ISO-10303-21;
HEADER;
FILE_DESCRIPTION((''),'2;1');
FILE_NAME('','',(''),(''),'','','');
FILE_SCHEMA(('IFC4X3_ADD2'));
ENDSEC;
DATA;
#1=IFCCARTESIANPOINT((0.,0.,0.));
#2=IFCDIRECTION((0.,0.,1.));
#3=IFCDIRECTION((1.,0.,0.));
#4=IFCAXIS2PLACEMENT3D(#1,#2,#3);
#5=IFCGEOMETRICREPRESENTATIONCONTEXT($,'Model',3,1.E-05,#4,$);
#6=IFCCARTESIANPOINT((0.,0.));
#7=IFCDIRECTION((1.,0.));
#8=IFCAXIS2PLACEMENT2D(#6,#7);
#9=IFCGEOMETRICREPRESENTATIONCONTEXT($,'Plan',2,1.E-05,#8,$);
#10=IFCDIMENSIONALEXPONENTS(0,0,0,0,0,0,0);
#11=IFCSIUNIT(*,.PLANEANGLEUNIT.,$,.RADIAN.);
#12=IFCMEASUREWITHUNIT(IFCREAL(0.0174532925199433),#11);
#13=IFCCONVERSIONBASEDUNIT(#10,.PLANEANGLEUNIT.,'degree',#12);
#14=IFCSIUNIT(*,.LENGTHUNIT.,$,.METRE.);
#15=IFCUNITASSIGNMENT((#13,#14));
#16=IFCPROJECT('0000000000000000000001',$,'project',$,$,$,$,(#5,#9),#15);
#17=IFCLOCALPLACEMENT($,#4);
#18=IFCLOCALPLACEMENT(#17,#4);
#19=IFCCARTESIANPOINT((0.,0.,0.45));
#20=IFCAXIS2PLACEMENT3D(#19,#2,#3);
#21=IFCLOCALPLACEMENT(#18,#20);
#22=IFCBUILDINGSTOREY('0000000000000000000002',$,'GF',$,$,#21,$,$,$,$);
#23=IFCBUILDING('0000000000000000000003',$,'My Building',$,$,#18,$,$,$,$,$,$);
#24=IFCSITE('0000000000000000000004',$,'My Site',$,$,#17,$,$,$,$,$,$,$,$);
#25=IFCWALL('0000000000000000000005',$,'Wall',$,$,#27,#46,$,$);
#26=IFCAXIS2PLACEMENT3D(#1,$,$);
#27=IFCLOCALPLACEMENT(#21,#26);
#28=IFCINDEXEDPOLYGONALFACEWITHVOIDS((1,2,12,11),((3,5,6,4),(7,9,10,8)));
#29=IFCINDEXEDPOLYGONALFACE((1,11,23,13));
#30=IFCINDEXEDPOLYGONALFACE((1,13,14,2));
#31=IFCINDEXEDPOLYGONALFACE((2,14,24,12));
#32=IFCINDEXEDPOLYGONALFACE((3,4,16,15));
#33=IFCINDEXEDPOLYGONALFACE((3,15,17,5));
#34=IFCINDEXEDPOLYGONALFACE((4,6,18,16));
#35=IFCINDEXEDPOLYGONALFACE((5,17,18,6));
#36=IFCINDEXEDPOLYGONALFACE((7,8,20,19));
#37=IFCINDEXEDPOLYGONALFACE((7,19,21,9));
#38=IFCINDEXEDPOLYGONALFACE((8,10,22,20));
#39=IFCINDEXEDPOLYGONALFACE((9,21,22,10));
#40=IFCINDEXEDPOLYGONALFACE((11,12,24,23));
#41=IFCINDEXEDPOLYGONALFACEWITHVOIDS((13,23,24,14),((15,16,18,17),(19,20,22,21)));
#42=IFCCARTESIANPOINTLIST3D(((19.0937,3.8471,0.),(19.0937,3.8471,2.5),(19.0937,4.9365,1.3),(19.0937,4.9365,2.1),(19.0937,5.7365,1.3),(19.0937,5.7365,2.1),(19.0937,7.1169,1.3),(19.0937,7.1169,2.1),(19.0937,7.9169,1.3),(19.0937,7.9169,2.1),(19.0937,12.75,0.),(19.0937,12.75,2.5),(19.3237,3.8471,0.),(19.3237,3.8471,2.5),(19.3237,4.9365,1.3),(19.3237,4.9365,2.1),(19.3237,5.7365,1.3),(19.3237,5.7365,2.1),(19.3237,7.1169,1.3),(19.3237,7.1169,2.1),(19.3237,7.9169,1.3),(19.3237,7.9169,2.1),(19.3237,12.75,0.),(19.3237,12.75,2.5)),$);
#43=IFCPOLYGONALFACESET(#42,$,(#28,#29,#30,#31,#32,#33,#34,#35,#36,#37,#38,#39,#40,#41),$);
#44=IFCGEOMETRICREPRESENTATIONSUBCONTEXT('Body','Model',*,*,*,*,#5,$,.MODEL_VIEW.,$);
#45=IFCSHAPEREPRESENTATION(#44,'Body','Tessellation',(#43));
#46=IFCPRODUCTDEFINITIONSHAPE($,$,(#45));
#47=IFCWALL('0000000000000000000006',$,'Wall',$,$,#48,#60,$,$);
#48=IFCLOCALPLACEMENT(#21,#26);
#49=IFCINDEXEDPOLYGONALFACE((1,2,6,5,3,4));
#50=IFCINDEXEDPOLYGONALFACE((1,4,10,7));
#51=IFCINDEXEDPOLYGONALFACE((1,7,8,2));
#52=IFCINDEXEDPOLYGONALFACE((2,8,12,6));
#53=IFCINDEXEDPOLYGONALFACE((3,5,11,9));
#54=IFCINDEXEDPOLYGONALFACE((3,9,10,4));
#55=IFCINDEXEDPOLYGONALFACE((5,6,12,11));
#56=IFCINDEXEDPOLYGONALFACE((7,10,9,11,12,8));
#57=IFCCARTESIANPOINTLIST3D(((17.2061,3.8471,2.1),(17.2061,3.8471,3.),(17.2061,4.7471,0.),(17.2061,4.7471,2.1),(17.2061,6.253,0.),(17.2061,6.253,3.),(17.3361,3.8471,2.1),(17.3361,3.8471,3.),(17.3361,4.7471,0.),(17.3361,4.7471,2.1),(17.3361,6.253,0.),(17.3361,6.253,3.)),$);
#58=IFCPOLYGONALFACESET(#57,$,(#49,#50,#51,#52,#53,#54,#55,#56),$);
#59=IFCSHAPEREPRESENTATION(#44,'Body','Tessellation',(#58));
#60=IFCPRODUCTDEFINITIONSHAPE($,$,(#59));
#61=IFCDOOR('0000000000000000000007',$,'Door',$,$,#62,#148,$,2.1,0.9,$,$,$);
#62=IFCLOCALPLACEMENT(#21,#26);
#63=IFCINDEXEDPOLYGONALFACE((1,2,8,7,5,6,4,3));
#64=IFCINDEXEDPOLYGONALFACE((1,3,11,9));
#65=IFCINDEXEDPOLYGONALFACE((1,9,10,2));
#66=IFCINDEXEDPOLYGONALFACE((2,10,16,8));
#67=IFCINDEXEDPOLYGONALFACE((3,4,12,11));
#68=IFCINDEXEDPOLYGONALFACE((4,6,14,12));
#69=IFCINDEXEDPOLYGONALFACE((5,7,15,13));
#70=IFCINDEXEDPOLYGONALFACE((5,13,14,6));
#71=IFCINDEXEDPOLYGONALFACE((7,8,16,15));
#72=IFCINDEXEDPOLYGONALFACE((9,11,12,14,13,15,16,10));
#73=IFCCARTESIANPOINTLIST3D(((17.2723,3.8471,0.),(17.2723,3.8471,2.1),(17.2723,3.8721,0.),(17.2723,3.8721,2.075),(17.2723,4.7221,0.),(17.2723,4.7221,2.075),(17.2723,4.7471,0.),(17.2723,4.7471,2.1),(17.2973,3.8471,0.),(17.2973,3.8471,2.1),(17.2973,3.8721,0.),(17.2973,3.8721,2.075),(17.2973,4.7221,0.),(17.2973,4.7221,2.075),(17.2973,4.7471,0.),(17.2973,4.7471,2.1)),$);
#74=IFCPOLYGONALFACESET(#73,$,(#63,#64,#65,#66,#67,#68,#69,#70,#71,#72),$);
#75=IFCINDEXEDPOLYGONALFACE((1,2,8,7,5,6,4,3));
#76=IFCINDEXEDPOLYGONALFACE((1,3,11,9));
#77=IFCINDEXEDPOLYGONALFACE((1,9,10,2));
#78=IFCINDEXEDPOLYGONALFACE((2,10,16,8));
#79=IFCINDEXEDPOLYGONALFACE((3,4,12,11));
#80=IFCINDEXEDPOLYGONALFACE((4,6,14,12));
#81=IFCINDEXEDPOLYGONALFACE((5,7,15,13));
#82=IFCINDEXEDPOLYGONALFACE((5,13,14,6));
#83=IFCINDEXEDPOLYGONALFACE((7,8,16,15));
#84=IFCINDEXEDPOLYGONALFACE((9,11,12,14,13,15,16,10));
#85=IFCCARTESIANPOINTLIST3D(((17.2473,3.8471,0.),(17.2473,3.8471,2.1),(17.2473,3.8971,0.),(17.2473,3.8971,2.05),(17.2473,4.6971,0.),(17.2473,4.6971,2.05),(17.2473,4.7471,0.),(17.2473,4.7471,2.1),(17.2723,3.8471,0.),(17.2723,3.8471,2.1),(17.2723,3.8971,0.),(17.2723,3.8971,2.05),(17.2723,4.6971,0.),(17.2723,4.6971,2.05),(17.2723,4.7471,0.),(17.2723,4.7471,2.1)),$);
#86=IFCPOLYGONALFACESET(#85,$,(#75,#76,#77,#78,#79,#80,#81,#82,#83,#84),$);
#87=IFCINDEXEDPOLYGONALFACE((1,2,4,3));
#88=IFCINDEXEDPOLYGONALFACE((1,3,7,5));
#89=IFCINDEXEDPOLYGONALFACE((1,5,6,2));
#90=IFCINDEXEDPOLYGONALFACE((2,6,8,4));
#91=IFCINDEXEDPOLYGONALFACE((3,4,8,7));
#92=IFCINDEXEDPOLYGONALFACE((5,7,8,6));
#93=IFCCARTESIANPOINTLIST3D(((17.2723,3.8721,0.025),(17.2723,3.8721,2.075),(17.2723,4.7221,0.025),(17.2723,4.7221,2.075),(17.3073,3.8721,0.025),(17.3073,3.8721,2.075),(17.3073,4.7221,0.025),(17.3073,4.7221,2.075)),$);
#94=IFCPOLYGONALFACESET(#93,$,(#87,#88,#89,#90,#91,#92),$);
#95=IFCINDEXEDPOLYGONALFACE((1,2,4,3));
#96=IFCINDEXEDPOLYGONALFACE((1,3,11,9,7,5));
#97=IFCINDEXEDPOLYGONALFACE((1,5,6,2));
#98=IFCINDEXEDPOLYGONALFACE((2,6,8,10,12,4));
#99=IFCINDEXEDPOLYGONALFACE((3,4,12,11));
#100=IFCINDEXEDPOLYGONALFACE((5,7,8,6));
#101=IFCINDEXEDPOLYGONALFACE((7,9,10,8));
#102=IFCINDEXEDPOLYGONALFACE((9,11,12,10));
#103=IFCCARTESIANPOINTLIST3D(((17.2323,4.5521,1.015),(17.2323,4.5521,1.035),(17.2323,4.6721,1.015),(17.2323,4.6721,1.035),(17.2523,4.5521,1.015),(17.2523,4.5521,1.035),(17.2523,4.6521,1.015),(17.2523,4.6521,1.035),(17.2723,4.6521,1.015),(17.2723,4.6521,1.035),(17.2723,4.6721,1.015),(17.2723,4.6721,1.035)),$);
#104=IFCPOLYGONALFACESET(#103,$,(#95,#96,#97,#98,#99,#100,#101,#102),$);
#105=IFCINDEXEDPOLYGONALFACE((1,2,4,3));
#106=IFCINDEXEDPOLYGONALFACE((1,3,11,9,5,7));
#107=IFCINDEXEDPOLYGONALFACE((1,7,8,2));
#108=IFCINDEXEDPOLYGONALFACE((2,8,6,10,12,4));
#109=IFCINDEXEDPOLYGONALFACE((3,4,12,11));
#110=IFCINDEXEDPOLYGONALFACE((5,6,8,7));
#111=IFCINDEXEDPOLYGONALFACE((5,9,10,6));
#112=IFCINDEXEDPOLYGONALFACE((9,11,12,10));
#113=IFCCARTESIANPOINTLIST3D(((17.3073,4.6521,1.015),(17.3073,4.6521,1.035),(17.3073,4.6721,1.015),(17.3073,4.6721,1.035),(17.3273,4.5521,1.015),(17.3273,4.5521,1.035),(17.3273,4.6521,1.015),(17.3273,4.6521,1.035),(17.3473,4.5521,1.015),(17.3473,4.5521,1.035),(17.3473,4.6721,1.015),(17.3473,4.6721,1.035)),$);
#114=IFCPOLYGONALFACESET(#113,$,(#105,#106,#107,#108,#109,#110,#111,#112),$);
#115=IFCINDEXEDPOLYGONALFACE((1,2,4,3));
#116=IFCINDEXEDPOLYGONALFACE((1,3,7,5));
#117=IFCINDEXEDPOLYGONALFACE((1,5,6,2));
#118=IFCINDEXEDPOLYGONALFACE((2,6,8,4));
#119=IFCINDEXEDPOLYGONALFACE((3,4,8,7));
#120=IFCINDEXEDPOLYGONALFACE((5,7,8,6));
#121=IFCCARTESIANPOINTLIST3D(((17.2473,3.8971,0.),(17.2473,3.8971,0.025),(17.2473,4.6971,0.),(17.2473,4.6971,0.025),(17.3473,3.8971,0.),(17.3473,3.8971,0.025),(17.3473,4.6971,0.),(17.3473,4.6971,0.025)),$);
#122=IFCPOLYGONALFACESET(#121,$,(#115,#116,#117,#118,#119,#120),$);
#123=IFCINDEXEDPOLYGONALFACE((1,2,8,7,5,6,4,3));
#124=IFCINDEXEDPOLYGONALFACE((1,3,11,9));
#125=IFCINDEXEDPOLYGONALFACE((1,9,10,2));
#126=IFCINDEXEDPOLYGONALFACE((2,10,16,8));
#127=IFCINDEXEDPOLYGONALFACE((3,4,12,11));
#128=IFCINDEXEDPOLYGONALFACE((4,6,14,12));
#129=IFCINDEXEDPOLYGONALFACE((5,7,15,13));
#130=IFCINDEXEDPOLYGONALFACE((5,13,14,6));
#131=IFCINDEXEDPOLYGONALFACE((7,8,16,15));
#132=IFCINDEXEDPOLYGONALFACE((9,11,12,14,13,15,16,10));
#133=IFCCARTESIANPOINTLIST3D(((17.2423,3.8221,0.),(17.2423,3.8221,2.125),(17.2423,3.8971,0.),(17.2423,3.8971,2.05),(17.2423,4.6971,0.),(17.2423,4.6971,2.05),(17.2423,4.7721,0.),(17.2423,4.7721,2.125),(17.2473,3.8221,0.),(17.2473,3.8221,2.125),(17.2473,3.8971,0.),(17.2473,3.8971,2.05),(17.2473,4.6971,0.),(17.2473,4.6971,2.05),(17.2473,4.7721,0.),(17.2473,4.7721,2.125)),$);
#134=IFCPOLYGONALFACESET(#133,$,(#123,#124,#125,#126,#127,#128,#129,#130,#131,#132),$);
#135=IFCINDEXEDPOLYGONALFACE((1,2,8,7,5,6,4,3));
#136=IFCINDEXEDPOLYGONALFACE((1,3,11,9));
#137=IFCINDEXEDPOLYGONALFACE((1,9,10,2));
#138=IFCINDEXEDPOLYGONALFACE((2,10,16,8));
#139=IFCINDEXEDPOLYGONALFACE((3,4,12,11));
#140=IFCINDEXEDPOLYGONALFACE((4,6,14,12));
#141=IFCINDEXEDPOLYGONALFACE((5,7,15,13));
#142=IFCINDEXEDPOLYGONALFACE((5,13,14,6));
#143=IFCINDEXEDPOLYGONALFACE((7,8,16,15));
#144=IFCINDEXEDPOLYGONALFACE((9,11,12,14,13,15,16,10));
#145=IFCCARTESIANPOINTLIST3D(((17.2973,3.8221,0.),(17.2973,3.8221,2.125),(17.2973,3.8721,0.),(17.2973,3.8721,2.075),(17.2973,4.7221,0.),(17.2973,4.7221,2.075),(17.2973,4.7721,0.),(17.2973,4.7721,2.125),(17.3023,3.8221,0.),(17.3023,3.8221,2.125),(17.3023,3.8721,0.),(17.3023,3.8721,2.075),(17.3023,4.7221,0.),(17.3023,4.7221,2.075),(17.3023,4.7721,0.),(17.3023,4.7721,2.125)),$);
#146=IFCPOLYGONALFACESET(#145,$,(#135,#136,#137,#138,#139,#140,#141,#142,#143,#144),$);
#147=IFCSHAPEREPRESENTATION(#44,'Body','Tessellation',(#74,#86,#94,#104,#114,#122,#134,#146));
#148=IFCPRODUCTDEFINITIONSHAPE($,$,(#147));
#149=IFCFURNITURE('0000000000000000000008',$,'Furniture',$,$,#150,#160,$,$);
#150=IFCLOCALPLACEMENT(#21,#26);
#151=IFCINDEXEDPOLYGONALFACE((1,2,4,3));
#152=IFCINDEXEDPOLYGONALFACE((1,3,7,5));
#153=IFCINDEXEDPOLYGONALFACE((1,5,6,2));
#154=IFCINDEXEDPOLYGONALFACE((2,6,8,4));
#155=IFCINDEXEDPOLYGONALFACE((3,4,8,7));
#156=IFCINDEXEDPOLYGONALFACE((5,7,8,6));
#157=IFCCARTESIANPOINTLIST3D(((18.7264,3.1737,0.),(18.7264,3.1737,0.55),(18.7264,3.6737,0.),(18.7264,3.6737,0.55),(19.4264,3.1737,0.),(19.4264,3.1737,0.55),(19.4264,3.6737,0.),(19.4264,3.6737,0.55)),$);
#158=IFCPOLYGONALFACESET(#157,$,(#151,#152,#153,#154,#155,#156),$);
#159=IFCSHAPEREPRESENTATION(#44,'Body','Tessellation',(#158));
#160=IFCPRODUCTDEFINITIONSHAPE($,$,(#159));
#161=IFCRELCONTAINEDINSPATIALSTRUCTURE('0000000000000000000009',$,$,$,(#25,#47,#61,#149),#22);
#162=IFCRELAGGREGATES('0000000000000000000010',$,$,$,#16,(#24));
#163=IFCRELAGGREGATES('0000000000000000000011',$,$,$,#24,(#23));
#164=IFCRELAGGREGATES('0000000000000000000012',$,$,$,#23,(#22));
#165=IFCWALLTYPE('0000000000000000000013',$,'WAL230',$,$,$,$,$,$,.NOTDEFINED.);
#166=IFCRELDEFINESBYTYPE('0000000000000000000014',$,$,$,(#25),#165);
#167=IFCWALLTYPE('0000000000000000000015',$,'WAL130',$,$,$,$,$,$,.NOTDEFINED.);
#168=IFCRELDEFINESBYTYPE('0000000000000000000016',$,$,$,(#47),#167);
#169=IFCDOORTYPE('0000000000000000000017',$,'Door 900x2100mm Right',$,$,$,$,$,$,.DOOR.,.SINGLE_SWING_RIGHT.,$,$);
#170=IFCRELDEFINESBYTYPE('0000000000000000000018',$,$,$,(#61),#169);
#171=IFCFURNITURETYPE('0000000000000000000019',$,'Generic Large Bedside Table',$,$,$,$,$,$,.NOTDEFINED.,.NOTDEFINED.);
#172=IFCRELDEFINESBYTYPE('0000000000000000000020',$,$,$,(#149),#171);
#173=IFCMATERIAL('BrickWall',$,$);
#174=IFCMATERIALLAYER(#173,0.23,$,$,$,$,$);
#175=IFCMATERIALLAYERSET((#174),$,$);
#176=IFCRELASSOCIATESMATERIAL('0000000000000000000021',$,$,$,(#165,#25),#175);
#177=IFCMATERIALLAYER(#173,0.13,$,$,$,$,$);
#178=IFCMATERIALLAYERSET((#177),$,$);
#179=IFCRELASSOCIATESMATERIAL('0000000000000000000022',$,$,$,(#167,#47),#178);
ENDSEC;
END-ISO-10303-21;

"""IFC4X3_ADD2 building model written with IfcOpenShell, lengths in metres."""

from ifc_helpers import new_model, entity, si_unit, converted_unit, frame, origin_with_axes, origin_2d_with_axis, place, context, subcontext, project, spatial, line, indexed_curve, outline, extrude, shape, source, transform, mapped, material, layer, layer_set, layer_usage, type_object, type_shapes, element, fill, save


model = new_model("IFC4X3_ADD2")

# Units and contexts
model_context = context("Model", 3, precision=1e-05, world=origin_with_axes())
plan_context = context("Plan", 2, precision=1e-05, world=origin_2d_with_axis())
body_context_1 = subcontext(model_context, "Body", "Model", "MODEL_VIEW")
body_context_2 = subcontext(plan_context, "Body", "Plan", "PLAN_VIEW")
ifc_project = project(units=[converted_unit("PLANEANGLEUNIT", "degree", entity("IfcReal", 0.0174532925199433), si_unit("PLANEANGLEUNIT", "RADIAN"), dimensions=[0, 0, 0, 0, 0, 0, 0]), si_unit("LENGTHUNIT", "METRE")], contexts=[model_context, plan_context])

# Site, building, storey
site_placement = place(None, origin_with_axes())
site = spatial("IfcSite", under=ifc_project, at=site_placement, Name="My Site")
building_placement = place(site_placement, origin_with_axes())
building = spatial("IfcBuilding", under=site, at=building_placement, Name="My Building")
storey_placement = place(building_placement, frame((0.0, 0.0, 0.45), z_axis=(0.0, 0.0, 1.0), x_axis=(1.0, 0.0, 0.0)))
storey = spatial("IfcBuildingStorey", under=building, at=storey_placement, Name="GF")

# Shared definitions
ifc_material = material(Name="BrickWall")
ifc_layer_1 = layer(ifc_material, 0.23)
ifc_layer_set_1 = layer_set([ifc_layer_1])
wall_type_1 = type_object("IfcWallType", Name="WAL230", PredefinedType="NOTDEFINED", material=ifc_layer_set_1)

# Wall, openings
ifc_layer_usage_1 = layer_usage(ifc_layer_set_1, "AXIS2", "POSITIVE", 0.0)
wall_1_placement = place(storey_placement, frame((19.3237, 3.8471, 0.0), z_axis=(0.0, 0.0, 1.0), x_axis=(0.0, 1.0, 0.0)))
wall_1 = element("IfcWall", 1, at=wall_1_placement, inside=storey, type_object=wall_type_1, material=ifc_layer_usage_1, Name="Wall", context=body_context_1, shape_type="SweptSolid", body=[
    extrude(outline(indexed_curve([(0.0, 0.0), (0.0, 0.23), (8.9029, 0.23), (8.9029, 0.0), (0.0, 0.0)], self_intersect=False)), origin_with_axes(), (0.0, 0.0, 1.0), 2.5),
])
shared_shape_1 = source(origin_with_axes(), body_context_1, "Body", "SweptSolid", [
    extrude(outline(indexed_curve([(0.0, 0.0), (0.8, 0.0), (0.8, 0.8), (0.0, 0.8)], segments=[line(1, 2, 3, 4, 1)])), frame((-0.4, -0.6, 0.0), z_axis=(0.0, -1.0, 0.0), x_axis=(1.0, 0.0, 0.0)), (0.0, 0.0, -1.0), 1.2),
])
opening_1_placement = place(wall_1_placement, frame((1.4894, 0.0, 1.3), z_axis=(0.0, 0.0, 1.0), x_axis=(1.0, 0.0, 0.0)))
element("IfcOpeningElement", 2, at=opening_1_placement, cuts=wall_1, PredefinedType="OPENING", context=body_context_1, shape_type="MappedRepresentation", body=[
    mapped(shared_shape_1, transform((0.0, 0.0, 0.0), x_axis=(1.0, 0.0, 0.0), y_axis=(0.0, 1.0, 0.0), z_axis=(0.0, 0.0, 1.0), scale=1.0)),
])
opening_2_placement = place(wall_1_placement, frame((3.6698, 0.0, 1.3), z_axis=(0.0, 0.0, 1.0), x_axis=(1.0, 0.0, 0.0)))
element("IfcOpeningElement", 3, at=opening_2_placement, cuts=wall_1, PredefinedType="OPENING", context=body_context_1, shape_type="MappedRepresentation", body=[
    mapped(shared_shape_1, transform((0.0, 0.0, 0.0), x_axis=(1.0, 0.0, 0.0), y_axis=(0.0, 1.0, 0.0), z_axis=(0.0, 0.0, 1.0), scale=1.0)),
])

# Wall, opening, door
ifc_layer_2 = layer(ifc_material, 0.13)
ifc_layer_set_2 = layer_set([ifc_layer_2])
ifc_layer_usage_2 = layer_usage(ifc_layer_set_2, "AXIS2", "POSITIVE", 0.0)
wall_type_2 = type_object("IfcWallType", Name="WAL130", PredefinedType="NOTDEFINED", material=ifc_layer_set_2)
wall_2_placement = place(storey_placement, frame((17.3361, 3.8471, 0.0), z_axis=(0.0, 0.0, 1.0), x_axis=(0.0, 1.0, 0.0)))
wall_2 = element("IfcWall", 4, at=wall_2_placement, inside=storey, type_object=wall_type_2, material=ifc_layer_usage_2, Name="Wall", context=body_context_1, shape_type="SweptSolid", body=[
    extrude(outline(indexed_curve([(0.0, 0.0), (0.0, 0.13), (2.4059, 0.13), (2.4059, 0.0), (0.0, 0.0)], self_intersect=False)), origin_with_axes(), (0.0, 0.0, 1.0), 3.0),
])
shared_shape_2 = source(origin_with_axes(), body_context_1, "Body", "SweptSolid", [
    extrude(outline(indexed_curve([(0.0, 0.0), (0.9, 0.0), (0.9, 2.1), (0.0, 2.1)], segments=[line(1, 2, 3, 4, 1)])), frame((0.0, -0.6, 0.0), z_axis=(0.0, -1.0, 0.0), x_axis=(1.0, 0.0, 0.0)), (0.0, 0.0, -1.0), 1.2),
])
opening_3_placement = place(wall_2_placement, frame((0.9, 0.0887, 0.0), z_axis=(0.0, 0.0, 1.0), x_axis=(-1.0, 0.0, 0.0)))
opening_3 = element("IfcOpeningElement", 5, at=opening_3_placement, cuts=wall_2, PredefinedType="OPENING", context=body_context_1, shape_type="MappedRepresentation", body=[
    mapped(shared_shape_2, transform((0.0, 0.0, 0.0), x_axis=(1.0, 0.0, 0.0), y_axis=(0.0, 1.0, 0.0), z_axis=(0.0, 0.0, 1.0), scale=1.0)),
])
door_type = type_object("IfcDoorType", Name="Door 900x2100mm Right", OperationType="SINGLE_SWING_RIGHT", PredefinedType="DOOR")
shared_shape_3 = source(origin_with_axes(), body_context_1, "Body", "SweptSolid", [
    extrude(outline(indexed_curve([(0.0, 0.0), (0.0, 2.1), (0.9, 2.1), (0.9, 0.0), (0.875, 0.0), (0.875, 2.075), (0.025, 2.075), (0.025, 0.0)], segments=[line(1, 2, 3, 4, 5, 6, 7, 8, 1)])), frame((0.0, 0.025, 0.0), z_axis=(0.0, -1.0, 0.0), x_axis=(1.0, 0.0, 0.0)), (0.0, 0.0, -1.0), 0.025),
    extrude(outline(indexed_curve([(0.0, 0.0), (0.0, 2.1), (0.9, 2.1), (0.9, 0.0), (0.85, 0.0), (0.85, 2.05), (0.05, 2.05), (0.05, 0.0)], segments=[line(1, 2, 3, 4, 5, 6, 7, 8, 1)])), frame((0.0, 0.0, 0.0), z_axis=(0.0, -1.0, 0.0), x_axis=(1.0, 0.0, 0.0)), (0.0, 0.0, -1.0), 0.025),
    extrude(outline(indexed_curve([(0.0, 0.0), (0.85, 0.0), (0.85, 0.035), (0.0, 0.035)], segments=[line(1, 2, 3, 4, 1)])), frame((0.025, 0.025, 0.025), z_axis=(0.0, 0.0, 1.0), x_axis=(1.0, 0.0, 0.0)), (0.0, 0.0, 1.0), 2.05),
    extrude(outline(indexed_curve([(0.0, 0.0), (0.0, -0.04), (0.12, -0.04), (0.12, -0.02), (0.02, -0.02), (0.02, 0.0)], segments=[line(1, 2, 3, 4, 5, 6, 1)])), frame((0.075, 0.025, 1.015), z_axis=(0.0, 0.0, 1.0), x_axis=(1.0, 0.0, 0.0)), (0.0, 0.0, 1.0), 0.02),
    extrude(outline(indexed_curve([(0.0, 0.0), (0.0, 0.04), (0.12, 0.04), (0.12, 0.02), (0.02, 0.02), (0.02, 0.0)], segments=[line(1, 2, 3, 4, 5, 6, 1)])), frame((0.075, 0.06, 1.015), z_axis=(0.0, 0.0, 1.0), x_axis=(1.0, 0.0, 0.0)), (0.0, 0.0, 1.0), 0.02),
    extrude(outline(indexed_curve([(0.0, 0.0), (0.8, 0.0), (0.8, 0.1), (0.0, 0.1)], segments=[line(1, 2, 3, 4, 1)])), frame((0.05, 0.0, 0.0), z_axis=(0.0, 0.0, 1.0), x_axis=(1.0, 0.0, 0.0)), (0.0, 0.0, 1.0), 0.025),
    extrude(outline(indexed_curve([(0.0, 0.0), (0.0, 2.125), (0.95, 2.125), (0.95, 0.0), (0.875, 0.0), (0.875, 2.05), (0.075, 2.05), (0.075, 0.0)], segments=[line(1, 2, 3, 4, 5, 6, 7, 8, 1)])), frame((-0.025, -0.005, 0.0), z_axis=(0.0, -1.0, 0.0), x_axis=(1.0, 0.0, 0.0)), (0.0, 0.0, -1.0), 0.005),
    extrude(outline(indexed_curve([(0.0, 0.0), (0.0, 2.125), (0.95, 2.125), (0.95, 0.0), (0.9, 0.0), (0.9, 2.075), (0.05, 2.075), (0.05, 0.0)], segments=[line(1, 2, 3, 4, 5, 6, 7, 8, 1)])), frame((-0.025, 0.05, 0.0), z_axis=(0.0, -1.0, 0.0), x_axis=(1.0, 0.0, 0.0)), (0.0, 0.0, -1.0), 0.005),
])
shared_shape_4 = source(origin_with_axes(), body_context_2, "Body", "Curve2D", [
    entity("IfcIndexedPolyCurve", entity("IfcCartesianPointList2D", [[0.0, 0.0], [0.0, 0.05], [0.025, 0.05], [0.025, 0.025], [0.05, 0.025], [0.05, 0.0]]), [entity("IfcLineIndex", [1, 2, 3, 4, 5, 6, 1])]),
    entity("IfcIndexedPolyCurve", entity("IfcCartesianPointList2D", [[0.9, 0.0], [0.9, 0.05], [0.875, 0.05], [0.875, 0.025], [0.85, 0.025], [0.85, 0.0]]), [entity("IfcLineIndex", [1, 2, 3, 4, 5, 6, 1])]),
    entity("IfcTrimmedCurve", entity("IfcEllipse", entity("IfcAxis2Placement2D", entity("IfcCartesianPoint", [0.84, 0.05]), entity("IfcDirection", [1.0, 0.0])), 0.815, 0.85), [entity("IfcCartesianPoint", [0.84, 0.9])], [entity("IfcCartesianPoint", [0.025, 0.05])], True, "CARTESIAN"),
    entity("IfcIndexedPolyCurve", entity("IfcCartesianPointList2D", [[0.875, 0.05], [0.84, 0.05], [0.84, 0.9], [0.875, 0.9]]), [entity("IfcLineIndex", [1, 2, 3, 4, 1])]),
])
type_shapes(door_type, [shared_shape_3, shared_shape_4])
door_placement = place(opening_3_placement, frame((0.0, 0.0, 0.0), z_axis=(0.0, 0.0, 1.0), x_axis=(1.0, 0.0, 0.0)))
door = element("IfcDoor", 6, at=door_placement, inside=storey, type_object=door_type, Name="Door", OverallHeight=2.1, OverallWidth=0.9, shapes=[
    shape(body_context_1, "Body", "MappedRepresentation", [mapped(shared_shape_3, transform((0.0, 0.0, 0.0), x_axis=(1.0, 0.0, 0.0), y_axis=(0.0, 1.0, 0.0), z_axis=(0.0, 0.0, 1.0), scale=1.0))]),
    shape(body_context_2, "Body", "MappedRepresentation", [mapped(shared_shape_4, transform((0.0, 0.0, 0.0), x_axis=(1.0, 0.0, 0.0), y_axis=(0.0, 1.0, 0.0), z_axis=(0.0, 0.0, 1.0), scale=1.0))]),
])
fill(opening_3, door)

# Furniture
furniture_type_1 = type_object("IfcFurnitureType", Name="Generic Large Bedside Table", AssemblyPlace="NOTDEFINED", PredefinedType="NOTDEFINED")
shared_shape_5 = source(origin_with_axes(), body_context_1, "Body", "SweptSolid", [
    extrude(outline(indexed_curve([(0.0, 0.0), (0.7, 0.0), (0.7, 0.5), (0.0, 0.5)], segments=[line(1, 2, 3, 4, 1)])), frame((-0.35, -0.25, 0.0), z_axis=(0.0, 0.0, 1.0), x_axis=(1.0, 0.0, 0.0)), (0.0, 0.0, 1.0), 0.55),
])
shared_shape_6 = source(origin_with_axes(), body_context_2, "Body", "Curve2D", [
    entity("IfcIndexedPolyCurve", entity("IfcCartesianPointList2D", [[-0.35, -0.25], [0.35, -0.25], [0.35, 0.25], [-0.35, 0.25]]), [entity("IfcLineIndex", [1, 2, 3, 4, 1])]),
])
type_shapes(furniture_type_1, [shared_shape_5, shared_shape_6])
for number, where, z_axis, x_axis, name in (
    (7, (19.0764, 3.4237, 0.0), (0.0, 0.0, 1.0), (1.0, 0.0, 0.0), "Furniture"),
):
    element("IfcFurniture", number, at=place(storey_placement, frame(where, z_axis=z_axis, x_axis=x_axis)), inside=storey, type_object=furniture_type_1, Name=name, shapes=[
        shape(body_context_1, "Body", "MappedRepresentation", [mapped(shared_shape_5, transform((0.0, 0.0, 0.0), x_axis=(1.0, 0.0, 0.0), y_axis=(0.0, 1.0, 0.0), z_axis=(0.0, 0.0, 1.0), scale=1.0))]),
        shape(body_context_2, "Body", "MappedRepresentation", [mapped(shared_shape_6, transform((0.0, 0.0, 0.0), x_axis=(1.0, 0.0, 0.0), y_axis=(0.0, 1.0, 0.0), z_axis=(0.0, 0.0, 1.0), scale=1.0))]),
    ])

save(model, "model.ifc")
